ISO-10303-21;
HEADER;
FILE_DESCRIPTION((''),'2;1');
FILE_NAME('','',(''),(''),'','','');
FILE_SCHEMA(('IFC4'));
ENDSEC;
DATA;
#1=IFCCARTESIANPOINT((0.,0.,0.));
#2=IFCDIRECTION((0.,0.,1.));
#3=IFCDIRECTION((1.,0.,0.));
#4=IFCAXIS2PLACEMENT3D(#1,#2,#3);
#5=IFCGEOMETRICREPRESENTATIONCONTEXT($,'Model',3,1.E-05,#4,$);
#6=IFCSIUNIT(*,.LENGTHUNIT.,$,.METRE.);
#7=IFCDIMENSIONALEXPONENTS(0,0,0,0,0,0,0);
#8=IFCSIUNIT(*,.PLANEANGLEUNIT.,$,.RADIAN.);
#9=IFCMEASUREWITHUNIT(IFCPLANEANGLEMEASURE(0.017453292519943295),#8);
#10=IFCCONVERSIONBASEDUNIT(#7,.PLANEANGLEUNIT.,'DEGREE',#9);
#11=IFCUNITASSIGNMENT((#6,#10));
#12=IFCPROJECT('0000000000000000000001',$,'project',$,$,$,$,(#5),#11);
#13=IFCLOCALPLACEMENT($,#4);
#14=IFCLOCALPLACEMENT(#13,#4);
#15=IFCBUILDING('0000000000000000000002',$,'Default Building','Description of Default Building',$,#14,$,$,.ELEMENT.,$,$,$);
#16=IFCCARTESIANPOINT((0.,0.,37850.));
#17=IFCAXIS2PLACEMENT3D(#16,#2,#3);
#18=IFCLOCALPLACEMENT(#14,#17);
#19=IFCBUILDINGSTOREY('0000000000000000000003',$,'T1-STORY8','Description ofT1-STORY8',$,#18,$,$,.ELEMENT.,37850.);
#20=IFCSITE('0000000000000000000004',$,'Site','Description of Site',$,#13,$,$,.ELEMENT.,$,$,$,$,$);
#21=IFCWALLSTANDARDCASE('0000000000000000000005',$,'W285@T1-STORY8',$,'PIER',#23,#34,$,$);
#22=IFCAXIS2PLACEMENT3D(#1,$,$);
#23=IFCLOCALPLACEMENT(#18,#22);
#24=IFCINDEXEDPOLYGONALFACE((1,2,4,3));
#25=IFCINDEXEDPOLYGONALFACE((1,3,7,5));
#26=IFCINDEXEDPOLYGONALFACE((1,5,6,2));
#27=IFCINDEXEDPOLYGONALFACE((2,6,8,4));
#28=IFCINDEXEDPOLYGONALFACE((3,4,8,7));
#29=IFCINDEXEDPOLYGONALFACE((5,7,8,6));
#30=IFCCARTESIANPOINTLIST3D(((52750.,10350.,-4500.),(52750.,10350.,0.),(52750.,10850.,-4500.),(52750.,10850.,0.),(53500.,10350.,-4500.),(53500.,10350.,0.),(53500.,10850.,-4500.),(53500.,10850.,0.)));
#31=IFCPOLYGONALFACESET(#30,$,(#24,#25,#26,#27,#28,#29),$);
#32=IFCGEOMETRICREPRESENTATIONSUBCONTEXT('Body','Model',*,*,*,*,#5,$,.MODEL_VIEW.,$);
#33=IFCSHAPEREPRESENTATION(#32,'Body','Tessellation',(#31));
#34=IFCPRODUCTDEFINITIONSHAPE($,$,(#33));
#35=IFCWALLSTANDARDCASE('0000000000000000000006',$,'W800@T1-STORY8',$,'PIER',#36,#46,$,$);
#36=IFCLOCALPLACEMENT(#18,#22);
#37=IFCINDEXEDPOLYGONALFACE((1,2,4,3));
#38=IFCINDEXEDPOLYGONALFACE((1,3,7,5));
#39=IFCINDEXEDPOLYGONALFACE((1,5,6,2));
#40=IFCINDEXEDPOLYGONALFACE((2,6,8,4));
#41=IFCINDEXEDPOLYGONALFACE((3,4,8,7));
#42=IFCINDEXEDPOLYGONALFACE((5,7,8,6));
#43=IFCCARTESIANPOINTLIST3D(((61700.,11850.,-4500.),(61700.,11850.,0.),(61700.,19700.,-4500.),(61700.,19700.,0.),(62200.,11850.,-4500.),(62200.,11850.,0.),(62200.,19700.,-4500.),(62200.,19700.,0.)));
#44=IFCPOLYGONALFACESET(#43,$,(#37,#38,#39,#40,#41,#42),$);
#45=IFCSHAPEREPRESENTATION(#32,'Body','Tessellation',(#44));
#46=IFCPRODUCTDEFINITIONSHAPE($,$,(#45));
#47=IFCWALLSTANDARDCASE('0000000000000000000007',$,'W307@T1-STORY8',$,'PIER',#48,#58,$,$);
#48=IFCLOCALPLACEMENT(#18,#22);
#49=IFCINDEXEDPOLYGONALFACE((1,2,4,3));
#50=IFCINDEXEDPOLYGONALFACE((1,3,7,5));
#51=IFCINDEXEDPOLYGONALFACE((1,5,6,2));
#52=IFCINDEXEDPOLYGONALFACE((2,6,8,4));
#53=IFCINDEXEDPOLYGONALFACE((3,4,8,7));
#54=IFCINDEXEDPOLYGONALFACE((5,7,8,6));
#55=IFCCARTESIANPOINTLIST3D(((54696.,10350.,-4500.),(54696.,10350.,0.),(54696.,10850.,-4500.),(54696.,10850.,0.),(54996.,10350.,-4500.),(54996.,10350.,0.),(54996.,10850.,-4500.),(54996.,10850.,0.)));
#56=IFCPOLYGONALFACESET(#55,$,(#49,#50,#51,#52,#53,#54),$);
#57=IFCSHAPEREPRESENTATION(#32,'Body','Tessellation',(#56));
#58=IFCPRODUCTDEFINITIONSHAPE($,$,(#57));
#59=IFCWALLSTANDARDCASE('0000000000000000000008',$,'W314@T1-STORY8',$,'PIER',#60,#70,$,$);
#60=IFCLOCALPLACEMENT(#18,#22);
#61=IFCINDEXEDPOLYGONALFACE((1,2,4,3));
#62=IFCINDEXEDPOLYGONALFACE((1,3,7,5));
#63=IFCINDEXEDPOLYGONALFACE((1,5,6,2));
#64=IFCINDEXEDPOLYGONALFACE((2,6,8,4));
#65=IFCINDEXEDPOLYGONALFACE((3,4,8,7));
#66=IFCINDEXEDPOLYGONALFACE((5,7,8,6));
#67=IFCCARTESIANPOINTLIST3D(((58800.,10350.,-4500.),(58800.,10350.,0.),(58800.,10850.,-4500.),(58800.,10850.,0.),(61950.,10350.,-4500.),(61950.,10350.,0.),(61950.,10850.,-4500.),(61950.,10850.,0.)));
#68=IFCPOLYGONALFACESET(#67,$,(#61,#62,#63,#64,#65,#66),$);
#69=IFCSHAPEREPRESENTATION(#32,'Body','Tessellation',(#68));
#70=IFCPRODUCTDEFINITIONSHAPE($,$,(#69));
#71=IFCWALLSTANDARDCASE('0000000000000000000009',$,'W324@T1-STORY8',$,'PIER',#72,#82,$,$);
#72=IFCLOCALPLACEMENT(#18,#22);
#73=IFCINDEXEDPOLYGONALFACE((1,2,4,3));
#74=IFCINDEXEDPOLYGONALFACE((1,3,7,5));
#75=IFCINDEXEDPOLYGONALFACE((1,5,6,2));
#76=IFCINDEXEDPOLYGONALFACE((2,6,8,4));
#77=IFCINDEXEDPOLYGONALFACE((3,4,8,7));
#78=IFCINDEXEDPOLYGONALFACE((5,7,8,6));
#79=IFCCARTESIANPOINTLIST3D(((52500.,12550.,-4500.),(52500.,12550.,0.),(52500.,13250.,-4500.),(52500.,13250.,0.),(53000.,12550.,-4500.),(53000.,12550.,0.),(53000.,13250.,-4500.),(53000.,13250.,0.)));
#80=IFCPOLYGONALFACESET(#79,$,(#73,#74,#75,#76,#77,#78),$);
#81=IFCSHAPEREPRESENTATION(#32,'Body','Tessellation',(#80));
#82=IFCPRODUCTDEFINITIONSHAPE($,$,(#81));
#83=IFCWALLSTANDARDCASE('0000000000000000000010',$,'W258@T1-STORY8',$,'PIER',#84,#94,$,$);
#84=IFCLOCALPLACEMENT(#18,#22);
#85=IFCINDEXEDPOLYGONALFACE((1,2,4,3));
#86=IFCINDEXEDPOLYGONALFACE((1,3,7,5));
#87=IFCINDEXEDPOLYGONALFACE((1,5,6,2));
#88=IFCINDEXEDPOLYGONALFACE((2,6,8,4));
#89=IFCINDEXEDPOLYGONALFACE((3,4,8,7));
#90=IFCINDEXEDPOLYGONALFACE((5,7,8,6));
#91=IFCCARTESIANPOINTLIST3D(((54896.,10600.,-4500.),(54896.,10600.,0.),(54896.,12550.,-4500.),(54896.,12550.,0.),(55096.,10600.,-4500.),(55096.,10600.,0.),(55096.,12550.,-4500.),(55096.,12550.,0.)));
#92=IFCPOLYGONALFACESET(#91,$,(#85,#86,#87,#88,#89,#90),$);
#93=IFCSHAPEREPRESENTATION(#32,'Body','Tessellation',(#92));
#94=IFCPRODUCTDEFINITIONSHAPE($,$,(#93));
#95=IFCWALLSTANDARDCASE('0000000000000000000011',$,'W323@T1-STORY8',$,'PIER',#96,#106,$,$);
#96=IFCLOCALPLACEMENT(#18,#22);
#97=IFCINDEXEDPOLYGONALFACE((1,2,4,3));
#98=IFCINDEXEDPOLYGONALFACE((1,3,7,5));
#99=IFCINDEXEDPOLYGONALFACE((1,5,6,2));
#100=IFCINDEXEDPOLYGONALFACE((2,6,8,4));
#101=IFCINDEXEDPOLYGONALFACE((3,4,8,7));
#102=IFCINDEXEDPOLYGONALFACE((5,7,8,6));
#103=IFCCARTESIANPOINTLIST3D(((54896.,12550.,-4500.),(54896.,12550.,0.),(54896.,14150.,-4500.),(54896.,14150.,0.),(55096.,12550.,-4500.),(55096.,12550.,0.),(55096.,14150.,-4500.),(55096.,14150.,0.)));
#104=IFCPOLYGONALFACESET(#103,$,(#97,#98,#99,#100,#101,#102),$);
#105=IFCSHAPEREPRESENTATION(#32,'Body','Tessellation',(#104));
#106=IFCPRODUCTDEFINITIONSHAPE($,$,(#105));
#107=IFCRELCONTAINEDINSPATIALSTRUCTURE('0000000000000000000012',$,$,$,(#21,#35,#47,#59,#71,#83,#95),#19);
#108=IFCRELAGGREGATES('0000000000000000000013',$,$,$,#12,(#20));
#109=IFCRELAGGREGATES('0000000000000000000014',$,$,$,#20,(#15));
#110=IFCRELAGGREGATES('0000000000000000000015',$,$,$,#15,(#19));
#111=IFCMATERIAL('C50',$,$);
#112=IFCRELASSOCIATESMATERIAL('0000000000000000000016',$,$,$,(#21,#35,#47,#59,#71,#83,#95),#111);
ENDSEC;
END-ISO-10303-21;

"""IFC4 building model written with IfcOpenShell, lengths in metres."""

from ifc_helpers import new_model, entity, si_unit, converted_unit, frame, origin_with_axes, place, context, subcontext, project, spatial, indexed_curve, outline, extrude, material, element, save


model = new_model("IFC4")

# Units and contexts
model_context = context("Model", 3, precision=1e-05, world=origin_with_axes())
body_context = subcontext(model_context, "Body", "Model", "MODEL_VIEW")
ifc_project = project(units=[si_unit("LENGTHUNIT", "METRE"), converted_unit("PLANEANGLEUNIT", "DEGREE", entity("IfcPlaneAngleMeasure", 0.017453292519943295), si_unit("PLANEANGLEUNIT", "RADIAN"), dimensions=[0, 0, 0, 0, 0, 0, 0])], contexts=[model_context])

# Site, building, storey
site_placement = place(None, origin_with_axes())
site = spatial("IfcSite", under=ifc_project, at=site_placement, Name="Site", Description="Description of Site", CompositionType="ELEMENT")
building_placement = place(site_placement, origin_with_axes())
building = spatial("IfcBuilding", under=site, at=building_placement, Name="Default Building", Description="Description of Default Building", CompositionType="ELEMENT")
storey_placement = place(building_placement, frame((0.0, 0.0, 37850.0), z_axis=(0.0, 0.0, 1.0), x_axis=(1.0, 0.0, 0.0)))
storey = spatial("IfcBuildingStorey", under=building, at=storey_placement, Name="T1-STORY8", Description="Description ofT1-STORY8", CompositionType="ELEMENT", Elevation=37850.0)

# Shared definitions
ifc_material_1 = material(Name="C50")

# Walls
wall_1_placement = place(storey_placement, frame((52750.0, 10600.0, -4500.0), z_axis=(0.0, 0.0, 1.0), x_axis=(1.0, 0.0, 0.0)))
element("IfcWallStandardCase", 1, at=wall_1_placement, inside=storey, material=ifc_material_1, Name="W285@T1-STORY8", ObjectType="PIER", context=body_context, shape_type="SweptSolid", body=[
    extrude(outline(indexed_curve([(0.0, -250.0), (0.0, 250.0), (750.0, 250.0), (750.0, -250.0), (0.0, -250.0)], self_intersect=False)), origin_with_axes(), (0.0, 0.0, 1.0), 4500.0),
])
wall_2_placement = place(storey_placement, frame((61950.0, 11850.0, -4500.0), z_axis=(0.0, 0.0, 1.0), x_axis=(0.0, 1.0, 0.0)))
element("IfcWallStandardCase", 2, at=wall_2_placement, inside=storey, material=ifc_material_1, Name="W800@T1-STORY8", ObjectType="PIER", context=body_context, shape_type="SweptSolid", body=[
    extrude(outline(indexed_curve([(0.0, -250.0), (0.0, 250.0), (7850.0, 250.0), (7850.0, -250.0), (0.0, -250.0)], self_intersect=False)), origin_with_axes(), (0.0, 0.0, 1.0), 4500.0),
])
wall_3_placement = place(storey_placement, frame((54696.0, 10600.0, -4500.0), z_axis=(0.0, 0.0, 1.0), x_axis=(1.0, 0.0, 0.0)))
element("IfcWallStandardCase", 3, at=wall_3_placement, inside=storey, material=ifc_material_1, Name="W307@T1-STORY8", ObjectType="PIER", context=body_context, shape_type="SweptSolid", body=[
    extrude(outline(indexed_curve([(0.0, -250.0), (0.0, 250.0), (300.0, 250.0), (300.0, -250.0), (0.0, -250.0)], self_intersect=False)), origin_with_axes(), (0.0, 0.0, 1.0), 4500.0),
])
wall_4_placement = place(storey_placement, frame((58800.0, 10600.0, -4500.0), z_axis=(0.0, 0.0, 1.0), x_axis=(1.0, 0.0, 0.0)))
element("IfcWallStandardCase", 4, at=wall_4_placement, inside=storey, material=ifc_material_1, Name="W314@T1-STORY8", ObjectType="PIER", context=body_context, shape_type="SweptSolid", body=[
    extrude(outline(indexed_curve([(0.0, -250.0), (0.0, 250.0), (3150.0, 250.0), (3150.0, -250.0), (0.0, -250.0)], self_intersect=False)), origin_with_axes(), (0.0, 0.0, 1.0), 4500.0),
])
wall_5_placement = place(storey_placement, frame((52750.0, 12550.0, -4500.0), z_axis=(0.0, 0.0, 1.0), x_axis=(0.0, 1.0, 0.0)))
element("IfcWallStandardCase", 5, at=wall_5_placement, inside=storey, material=ifc_material_1, Name="W324@T1-STORY8", ObjectType="PIER", context=body_context, shape_type="SweptSolid", body=[
    extrude(outline(indexed_curve([(0.0, -250.0), (0.0, 250.0), (700.0, 250.0), (700.0, -250.0), (0.0, -250.0)], self_intersect=False)), origin_with_axes(), (0.0, 0.0, 1.0), 4500.0),
])
wall_6_placement = place(storey_placement, frame((54996.0, 10600.0, -4500.0), z_axis=(0.0, 0.0, 1.0), x_axis=(0.0, 1.0, 0.0)))
element("IfcWallStandardCase", 6, at=wall_6_placement, inside=storey, material=ifc_material_1, Name="W258@T1-STORY8", ObjectType="PIER", context=body_context, shape_type="SweptSolid", body=[
    extrude(outline(indexed_curve([(0.0, -100.0), (0.0, 100.0), (1950.0, 100.0), (1950.0, -100.0), (0.0, -100.0)], self_intersect=False)), origin_with_axes(), (0.0, 0.0, 1.0), 4500.0),
])
wall_7_placement = place(storey_placement, frame((54996.0, 12550.0, -4500.0), z_axis=(0.0, 0.0, 1.0), x_axis=(0.0, 1.0, 0.0)))
element("IfcWallStandardCase", 7, at=wall_7_placement, inside=storey, material=ifc_material_1, Name="W323@T1-STORY8", ObjectType="PIER", context=body_context, shape_type="SweptSolid", body=[
    extrude(outline(indexed_curve([(0.0, -100.0), (0.0, 100.0), (1600.0, 100.0), (1600.0, -100.0), (0.0, -100.0)], self_intersect=False)), origin_with_axes(), (0.0, 0.0, 1.0), 4500.0),
])

save(model, "model.ifc")
